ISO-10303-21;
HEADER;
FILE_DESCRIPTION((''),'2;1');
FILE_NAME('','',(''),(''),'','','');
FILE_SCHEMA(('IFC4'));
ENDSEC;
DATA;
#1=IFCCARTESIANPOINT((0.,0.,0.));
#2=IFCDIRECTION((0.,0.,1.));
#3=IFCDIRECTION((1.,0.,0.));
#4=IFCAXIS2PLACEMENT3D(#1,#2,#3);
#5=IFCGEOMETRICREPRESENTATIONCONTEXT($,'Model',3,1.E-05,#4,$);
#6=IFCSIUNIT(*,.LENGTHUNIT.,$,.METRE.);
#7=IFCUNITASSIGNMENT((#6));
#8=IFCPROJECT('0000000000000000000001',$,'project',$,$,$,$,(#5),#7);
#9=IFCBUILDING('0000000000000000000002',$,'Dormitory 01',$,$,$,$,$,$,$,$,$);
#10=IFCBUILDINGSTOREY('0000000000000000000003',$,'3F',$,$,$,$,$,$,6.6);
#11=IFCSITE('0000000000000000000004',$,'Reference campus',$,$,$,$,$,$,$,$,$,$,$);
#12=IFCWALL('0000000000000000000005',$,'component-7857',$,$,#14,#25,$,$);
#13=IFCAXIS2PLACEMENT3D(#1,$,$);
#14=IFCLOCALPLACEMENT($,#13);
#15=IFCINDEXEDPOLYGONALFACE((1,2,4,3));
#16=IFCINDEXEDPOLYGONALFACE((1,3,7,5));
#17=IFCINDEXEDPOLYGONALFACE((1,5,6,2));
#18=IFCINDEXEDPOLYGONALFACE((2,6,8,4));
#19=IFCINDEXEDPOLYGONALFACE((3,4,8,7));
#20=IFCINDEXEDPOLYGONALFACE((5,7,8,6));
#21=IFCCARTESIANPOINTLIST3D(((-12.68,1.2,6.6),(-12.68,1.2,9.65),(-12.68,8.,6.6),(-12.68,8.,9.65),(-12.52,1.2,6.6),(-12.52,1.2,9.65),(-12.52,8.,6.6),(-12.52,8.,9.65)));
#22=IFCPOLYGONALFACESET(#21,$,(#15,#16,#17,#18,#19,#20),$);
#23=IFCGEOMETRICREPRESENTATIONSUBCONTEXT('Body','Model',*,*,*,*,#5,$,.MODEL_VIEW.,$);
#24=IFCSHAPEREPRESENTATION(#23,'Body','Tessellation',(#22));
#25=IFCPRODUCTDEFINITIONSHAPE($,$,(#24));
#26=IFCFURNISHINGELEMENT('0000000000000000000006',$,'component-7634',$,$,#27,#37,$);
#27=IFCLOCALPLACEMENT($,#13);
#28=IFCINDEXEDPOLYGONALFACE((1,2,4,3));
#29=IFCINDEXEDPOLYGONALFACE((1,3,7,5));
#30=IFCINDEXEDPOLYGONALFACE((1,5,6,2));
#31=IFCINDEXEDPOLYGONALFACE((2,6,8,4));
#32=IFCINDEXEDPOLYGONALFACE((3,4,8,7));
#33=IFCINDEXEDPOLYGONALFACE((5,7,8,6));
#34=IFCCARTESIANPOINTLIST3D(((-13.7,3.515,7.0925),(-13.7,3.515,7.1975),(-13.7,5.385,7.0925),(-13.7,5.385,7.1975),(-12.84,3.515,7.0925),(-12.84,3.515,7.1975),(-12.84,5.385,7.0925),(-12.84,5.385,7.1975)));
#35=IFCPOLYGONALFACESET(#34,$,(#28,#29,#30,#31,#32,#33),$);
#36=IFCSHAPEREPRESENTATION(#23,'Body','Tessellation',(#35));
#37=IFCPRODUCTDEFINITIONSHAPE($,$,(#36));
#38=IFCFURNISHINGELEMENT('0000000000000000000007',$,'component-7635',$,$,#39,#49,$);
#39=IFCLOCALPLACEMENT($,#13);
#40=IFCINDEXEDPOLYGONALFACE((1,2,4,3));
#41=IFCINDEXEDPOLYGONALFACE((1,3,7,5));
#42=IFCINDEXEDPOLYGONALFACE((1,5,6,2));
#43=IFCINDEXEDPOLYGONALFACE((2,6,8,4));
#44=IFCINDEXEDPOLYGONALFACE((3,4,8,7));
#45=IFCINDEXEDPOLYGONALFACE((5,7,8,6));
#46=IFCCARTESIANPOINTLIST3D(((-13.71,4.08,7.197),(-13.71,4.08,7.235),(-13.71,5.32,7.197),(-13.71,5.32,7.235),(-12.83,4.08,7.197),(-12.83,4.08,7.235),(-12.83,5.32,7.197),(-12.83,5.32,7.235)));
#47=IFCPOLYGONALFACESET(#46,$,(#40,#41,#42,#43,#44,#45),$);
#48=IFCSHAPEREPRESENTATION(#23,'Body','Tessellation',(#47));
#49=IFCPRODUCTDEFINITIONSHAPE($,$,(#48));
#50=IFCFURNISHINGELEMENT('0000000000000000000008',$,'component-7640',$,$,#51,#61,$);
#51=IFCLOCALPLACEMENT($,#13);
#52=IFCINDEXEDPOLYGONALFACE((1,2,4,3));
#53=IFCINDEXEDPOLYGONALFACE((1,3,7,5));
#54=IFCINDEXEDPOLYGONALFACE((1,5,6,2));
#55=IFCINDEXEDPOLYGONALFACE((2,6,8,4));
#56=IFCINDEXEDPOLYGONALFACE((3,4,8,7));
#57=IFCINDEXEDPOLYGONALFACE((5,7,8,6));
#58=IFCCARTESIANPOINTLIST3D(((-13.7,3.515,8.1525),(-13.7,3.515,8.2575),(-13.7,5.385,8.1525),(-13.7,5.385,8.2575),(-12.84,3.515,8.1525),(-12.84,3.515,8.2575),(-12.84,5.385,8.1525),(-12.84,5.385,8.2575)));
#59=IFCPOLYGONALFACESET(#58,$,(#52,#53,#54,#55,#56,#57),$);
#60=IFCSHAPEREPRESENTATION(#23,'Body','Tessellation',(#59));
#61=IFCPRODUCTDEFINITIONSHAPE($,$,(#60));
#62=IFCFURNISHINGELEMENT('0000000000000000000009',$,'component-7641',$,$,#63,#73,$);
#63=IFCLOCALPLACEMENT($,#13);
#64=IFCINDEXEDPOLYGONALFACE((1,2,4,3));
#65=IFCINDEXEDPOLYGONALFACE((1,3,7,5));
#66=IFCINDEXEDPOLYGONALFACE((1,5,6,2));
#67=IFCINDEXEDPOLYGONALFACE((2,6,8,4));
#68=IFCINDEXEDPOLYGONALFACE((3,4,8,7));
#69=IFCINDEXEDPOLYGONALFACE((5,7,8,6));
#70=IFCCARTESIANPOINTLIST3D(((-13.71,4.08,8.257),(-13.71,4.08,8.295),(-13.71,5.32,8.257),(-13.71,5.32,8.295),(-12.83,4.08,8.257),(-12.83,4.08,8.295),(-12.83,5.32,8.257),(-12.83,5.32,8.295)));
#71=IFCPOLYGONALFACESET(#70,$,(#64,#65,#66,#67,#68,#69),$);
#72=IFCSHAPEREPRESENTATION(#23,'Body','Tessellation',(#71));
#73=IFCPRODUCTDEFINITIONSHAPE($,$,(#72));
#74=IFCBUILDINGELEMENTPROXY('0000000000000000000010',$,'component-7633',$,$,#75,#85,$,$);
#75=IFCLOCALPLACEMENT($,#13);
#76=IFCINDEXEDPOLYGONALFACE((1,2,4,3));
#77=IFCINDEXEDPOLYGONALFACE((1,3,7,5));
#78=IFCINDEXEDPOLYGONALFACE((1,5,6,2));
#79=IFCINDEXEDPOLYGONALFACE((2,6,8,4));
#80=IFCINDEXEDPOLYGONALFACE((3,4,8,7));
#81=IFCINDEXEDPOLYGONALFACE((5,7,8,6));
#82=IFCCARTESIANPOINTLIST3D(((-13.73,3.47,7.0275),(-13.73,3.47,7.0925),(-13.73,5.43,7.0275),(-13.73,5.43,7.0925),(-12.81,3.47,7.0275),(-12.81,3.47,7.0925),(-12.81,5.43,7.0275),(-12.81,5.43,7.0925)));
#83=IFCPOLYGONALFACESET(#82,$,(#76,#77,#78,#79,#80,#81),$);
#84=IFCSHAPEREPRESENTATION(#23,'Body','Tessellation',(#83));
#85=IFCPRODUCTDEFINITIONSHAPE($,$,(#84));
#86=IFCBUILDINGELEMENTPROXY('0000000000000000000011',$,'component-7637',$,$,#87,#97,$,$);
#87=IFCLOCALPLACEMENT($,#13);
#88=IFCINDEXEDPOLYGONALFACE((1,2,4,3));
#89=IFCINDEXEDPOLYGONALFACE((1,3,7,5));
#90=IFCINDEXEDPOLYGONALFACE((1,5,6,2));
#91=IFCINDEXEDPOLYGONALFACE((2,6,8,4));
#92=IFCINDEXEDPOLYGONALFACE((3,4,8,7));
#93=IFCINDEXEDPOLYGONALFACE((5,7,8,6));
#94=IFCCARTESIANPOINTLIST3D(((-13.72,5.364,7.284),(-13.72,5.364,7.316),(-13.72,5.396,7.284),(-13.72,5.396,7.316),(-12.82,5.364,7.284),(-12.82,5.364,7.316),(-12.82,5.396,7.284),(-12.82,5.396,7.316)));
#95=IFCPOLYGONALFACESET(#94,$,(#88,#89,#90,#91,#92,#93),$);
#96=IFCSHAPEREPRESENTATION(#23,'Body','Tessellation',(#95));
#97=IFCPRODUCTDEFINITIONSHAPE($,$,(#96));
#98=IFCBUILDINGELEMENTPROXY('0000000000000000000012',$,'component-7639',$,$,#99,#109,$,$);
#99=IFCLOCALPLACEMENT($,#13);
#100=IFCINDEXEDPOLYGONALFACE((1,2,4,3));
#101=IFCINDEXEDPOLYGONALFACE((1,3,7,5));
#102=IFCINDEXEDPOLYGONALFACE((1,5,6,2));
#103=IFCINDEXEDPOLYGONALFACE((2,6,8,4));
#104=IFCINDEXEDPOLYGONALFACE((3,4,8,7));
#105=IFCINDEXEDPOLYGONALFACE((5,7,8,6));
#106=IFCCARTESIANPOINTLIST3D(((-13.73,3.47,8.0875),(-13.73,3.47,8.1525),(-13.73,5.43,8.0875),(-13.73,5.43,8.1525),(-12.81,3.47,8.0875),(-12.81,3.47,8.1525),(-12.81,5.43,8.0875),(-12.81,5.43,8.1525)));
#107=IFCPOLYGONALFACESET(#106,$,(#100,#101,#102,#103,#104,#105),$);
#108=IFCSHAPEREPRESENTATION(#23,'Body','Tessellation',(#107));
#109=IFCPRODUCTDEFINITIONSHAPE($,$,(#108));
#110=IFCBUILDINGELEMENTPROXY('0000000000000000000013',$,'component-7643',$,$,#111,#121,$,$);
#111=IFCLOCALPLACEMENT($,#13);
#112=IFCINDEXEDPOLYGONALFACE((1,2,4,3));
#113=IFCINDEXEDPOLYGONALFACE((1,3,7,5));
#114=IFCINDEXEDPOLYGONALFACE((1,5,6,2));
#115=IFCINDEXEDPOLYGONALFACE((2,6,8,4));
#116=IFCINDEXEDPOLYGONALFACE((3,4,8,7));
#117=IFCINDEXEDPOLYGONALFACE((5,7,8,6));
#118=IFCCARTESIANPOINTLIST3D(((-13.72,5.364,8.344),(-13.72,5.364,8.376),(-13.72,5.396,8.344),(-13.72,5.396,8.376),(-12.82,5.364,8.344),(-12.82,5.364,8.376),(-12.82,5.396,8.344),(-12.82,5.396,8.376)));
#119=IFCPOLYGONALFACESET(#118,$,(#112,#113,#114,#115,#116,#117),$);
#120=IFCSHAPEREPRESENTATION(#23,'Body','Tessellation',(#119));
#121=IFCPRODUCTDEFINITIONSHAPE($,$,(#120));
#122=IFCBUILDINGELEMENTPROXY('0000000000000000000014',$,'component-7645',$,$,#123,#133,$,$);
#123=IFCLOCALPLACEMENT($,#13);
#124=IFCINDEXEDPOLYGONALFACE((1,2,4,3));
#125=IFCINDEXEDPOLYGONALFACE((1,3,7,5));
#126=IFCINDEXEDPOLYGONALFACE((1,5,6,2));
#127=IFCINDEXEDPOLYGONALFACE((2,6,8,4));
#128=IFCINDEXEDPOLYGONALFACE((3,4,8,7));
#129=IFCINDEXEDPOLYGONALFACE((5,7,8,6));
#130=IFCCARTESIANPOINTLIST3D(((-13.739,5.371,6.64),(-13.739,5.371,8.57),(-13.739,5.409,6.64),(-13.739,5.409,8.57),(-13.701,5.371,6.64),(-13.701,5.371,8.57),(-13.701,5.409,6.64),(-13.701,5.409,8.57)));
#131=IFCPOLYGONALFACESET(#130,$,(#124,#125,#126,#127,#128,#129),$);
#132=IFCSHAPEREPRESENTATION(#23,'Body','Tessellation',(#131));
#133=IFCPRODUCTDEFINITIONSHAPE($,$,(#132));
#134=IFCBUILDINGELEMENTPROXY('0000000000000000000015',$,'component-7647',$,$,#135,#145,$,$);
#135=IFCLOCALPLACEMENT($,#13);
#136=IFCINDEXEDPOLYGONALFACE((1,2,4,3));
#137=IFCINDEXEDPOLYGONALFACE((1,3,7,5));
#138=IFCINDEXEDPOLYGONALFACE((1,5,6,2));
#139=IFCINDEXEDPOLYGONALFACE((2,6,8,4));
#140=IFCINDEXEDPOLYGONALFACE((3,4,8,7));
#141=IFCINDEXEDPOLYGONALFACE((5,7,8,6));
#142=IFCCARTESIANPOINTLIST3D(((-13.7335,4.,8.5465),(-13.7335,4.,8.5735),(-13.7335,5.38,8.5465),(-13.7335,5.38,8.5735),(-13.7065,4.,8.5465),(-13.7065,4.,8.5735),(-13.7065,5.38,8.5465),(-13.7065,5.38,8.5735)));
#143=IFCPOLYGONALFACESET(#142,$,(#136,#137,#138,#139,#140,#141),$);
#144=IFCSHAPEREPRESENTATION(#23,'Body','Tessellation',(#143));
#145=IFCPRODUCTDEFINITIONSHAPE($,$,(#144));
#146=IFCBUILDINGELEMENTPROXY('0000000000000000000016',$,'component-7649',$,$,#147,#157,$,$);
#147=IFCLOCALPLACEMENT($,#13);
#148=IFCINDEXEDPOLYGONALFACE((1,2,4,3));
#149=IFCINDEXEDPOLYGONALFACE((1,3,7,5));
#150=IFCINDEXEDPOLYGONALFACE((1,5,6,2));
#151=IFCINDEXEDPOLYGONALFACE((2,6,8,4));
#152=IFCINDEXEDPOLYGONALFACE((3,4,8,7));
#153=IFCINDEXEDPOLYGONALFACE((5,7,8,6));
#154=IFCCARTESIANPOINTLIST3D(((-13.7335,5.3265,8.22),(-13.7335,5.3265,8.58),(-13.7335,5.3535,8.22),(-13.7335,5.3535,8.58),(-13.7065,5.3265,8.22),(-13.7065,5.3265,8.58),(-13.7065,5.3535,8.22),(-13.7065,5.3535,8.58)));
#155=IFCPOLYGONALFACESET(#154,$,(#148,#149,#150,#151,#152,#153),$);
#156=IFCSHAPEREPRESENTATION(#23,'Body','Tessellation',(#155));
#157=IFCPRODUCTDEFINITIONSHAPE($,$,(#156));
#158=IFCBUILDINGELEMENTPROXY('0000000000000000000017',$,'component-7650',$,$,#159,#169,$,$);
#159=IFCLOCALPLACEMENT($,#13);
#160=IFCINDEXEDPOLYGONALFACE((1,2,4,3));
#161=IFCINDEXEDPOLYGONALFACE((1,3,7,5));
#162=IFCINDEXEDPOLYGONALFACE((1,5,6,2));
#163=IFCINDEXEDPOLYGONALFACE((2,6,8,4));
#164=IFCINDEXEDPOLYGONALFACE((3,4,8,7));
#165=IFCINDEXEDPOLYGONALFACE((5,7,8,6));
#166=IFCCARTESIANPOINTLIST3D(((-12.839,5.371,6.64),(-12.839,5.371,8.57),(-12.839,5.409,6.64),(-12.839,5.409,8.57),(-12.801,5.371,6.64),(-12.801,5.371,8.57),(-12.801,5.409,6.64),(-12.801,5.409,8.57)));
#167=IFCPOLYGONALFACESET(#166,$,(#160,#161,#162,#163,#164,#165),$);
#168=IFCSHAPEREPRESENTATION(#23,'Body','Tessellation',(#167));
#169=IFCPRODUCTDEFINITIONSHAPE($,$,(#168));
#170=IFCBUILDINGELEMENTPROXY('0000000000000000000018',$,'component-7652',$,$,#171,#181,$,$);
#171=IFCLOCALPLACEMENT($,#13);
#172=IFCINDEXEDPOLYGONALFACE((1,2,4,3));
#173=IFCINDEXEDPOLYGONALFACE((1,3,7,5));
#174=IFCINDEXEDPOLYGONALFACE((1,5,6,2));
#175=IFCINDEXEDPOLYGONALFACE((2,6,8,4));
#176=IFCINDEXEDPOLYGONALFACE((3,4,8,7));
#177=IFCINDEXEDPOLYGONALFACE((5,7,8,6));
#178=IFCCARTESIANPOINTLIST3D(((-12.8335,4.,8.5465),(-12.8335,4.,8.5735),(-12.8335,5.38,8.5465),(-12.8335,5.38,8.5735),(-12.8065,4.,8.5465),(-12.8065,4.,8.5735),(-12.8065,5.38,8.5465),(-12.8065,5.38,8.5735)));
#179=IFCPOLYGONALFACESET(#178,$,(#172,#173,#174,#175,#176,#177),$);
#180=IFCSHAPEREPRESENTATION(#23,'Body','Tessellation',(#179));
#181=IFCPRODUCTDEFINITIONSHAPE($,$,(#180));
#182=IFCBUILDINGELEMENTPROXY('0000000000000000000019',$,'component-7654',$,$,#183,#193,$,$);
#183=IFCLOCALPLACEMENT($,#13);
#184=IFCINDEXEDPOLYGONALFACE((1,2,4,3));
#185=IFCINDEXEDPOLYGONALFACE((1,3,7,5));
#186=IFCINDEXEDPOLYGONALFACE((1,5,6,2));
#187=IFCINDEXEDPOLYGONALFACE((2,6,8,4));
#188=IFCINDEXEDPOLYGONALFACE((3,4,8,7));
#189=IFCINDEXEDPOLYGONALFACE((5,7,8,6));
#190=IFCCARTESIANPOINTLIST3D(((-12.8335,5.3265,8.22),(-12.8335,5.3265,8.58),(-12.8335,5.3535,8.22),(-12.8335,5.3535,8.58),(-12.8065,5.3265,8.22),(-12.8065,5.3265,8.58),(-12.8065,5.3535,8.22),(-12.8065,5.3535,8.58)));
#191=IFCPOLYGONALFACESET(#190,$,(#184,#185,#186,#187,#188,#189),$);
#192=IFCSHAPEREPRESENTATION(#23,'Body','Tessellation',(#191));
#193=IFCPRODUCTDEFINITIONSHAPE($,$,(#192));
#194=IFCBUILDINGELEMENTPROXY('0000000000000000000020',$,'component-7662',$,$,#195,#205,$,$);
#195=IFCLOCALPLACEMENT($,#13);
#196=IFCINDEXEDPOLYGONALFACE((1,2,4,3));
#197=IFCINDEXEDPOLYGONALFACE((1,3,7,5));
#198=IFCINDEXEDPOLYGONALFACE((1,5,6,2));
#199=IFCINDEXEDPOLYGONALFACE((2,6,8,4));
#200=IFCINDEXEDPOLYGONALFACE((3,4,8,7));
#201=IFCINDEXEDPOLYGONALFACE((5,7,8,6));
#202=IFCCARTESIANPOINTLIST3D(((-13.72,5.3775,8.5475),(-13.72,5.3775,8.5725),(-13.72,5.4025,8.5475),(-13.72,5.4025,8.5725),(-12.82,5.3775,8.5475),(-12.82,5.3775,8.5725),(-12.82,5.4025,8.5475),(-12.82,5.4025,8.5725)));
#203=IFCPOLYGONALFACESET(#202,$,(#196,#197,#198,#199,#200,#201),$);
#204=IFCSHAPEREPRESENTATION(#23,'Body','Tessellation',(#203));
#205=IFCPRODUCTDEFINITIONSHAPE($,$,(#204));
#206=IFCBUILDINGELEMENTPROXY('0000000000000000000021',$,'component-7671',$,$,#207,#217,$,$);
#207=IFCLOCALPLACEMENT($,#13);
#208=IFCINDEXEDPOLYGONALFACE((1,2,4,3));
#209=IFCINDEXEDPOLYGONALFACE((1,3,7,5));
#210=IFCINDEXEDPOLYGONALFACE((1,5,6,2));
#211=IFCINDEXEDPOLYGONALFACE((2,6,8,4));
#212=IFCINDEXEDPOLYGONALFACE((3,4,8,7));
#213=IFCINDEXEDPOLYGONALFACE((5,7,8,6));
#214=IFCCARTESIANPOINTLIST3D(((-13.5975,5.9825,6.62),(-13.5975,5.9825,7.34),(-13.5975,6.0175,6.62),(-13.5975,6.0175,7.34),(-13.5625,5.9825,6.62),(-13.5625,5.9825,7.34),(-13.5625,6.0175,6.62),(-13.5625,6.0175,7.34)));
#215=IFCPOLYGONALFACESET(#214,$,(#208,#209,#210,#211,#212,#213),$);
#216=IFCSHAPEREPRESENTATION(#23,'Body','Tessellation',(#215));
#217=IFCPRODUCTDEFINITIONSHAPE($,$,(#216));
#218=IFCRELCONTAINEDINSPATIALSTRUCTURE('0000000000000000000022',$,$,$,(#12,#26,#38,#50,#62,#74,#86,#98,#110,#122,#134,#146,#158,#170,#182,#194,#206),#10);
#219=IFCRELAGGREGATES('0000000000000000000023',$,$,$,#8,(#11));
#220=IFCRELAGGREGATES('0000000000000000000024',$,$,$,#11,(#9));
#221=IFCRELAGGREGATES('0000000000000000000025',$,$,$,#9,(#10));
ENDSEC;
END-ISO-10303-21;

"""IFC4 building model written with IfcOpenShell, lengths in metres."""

from ifc_helpers import new_model, si_unit, frame, origin, origin_with_axes, origin_2d, place, context, subcontext, project, spatial, rectangle, extrude, element, save


model = new_model("IFC4")

# Units and contexts
model_context = context("Model", 3, precision=1e-05, world=origin_with_axes())
body_context = subcontext(model_context, "Body", "Model", "MODEL_VIEW")
ifc_project = project(units=[si_unit("LENGTHUNIT", "METRE")], contexts=[model_context])

# Site, building, storey
site = spatial("IfcSite", under=ifc_project, Name="Reference campus")
building = spatial("IfcBuilding", under=site, Name="Dormitory 01")
storey = spatial("IfcBuildingStorey", under=building, Name="3F", Elevation=6.6)

# Wall
wall_placement = place(None, frame((-12.6, 4.6, 6.6), z_axis=(0.0, 0.0, 1.0), x_axis=(1.0, 0.0, 0.0)))
element("IfcWall", 1, at=wall_placement, inside=storey, Name="component-7857", context=body_context, shape_type="SweptSolid", body=[
    extrude(rectangle(XDim=0.16, YDim=6.8, at=origin_2d()), origin(), (0.0, 0.0, 1.0), 3.05),
])

# Furnishing elements
furnishing_1_placement = place(None, frame((-13.27, 4.45, 7.0925), z_axis=(0.0, 0.0, 1.0), x_axis=(1.0, 0.0, 0.0)))
element("IfcFurnishingElement", 2, at=furnishing_1_placement, inside=storey, Name="component-7634", context=body_context, shape_type="SweptSolid", body=[
    extrude(rectangle(XDim=0.86, YDim=1.87, at=origin_2d()), origin(), (0.0, 0.0, 1.0), 0.105),
])
furnishing_2_placement = place(None, frame((-13.27, 4.7, 7.197), z_axis=(0.0, 0.0, 1.0), x_axis=(1.0, 0.0, 0.0)))
element("IfcFurnishingElement", 3, at=furnishing_2_placement, inside=storey, Name="component-7635", context=body_context, shape_type="SweptSolid", body=[
    extrude(rectangle(XDim=0.88, YDim=1.24, at=origin_2d()), origin(), (0.0, 0.0, 1.0), 0.038),
])
furnishing_3_placement = place(None, frame((-13.27, 4.45, 8.1525), z_axis=(0.0, 0.0, 1.0), x_axis=(1.0, 0.0, 0.0)))
element("IfcFurnishingElement", 4, at=furnishing_3_placement, inside=storey, Name="component-7640", context=body_context, shape_type="SweptSolid", body=[
    extrude(rectangle(XDim=0.86, YDim=1.87, at=origin_2d()), origin(), (0.0, 0.0, 1.0), 0.105),
])
furnishing_4_placement = place(None, frame((-13.27, 4.7, 8.257), z_axis=(0.0, 0.0, 1.0), x_axis=(1.0, 0.0, 0.0)))
element("IfcFurnishingElement", 5, at=furnishing_4_placement, inside=storey, Name="component-7641", context=body_context, shape_type="SweptSolid", body=[
    extrude(rectangle(XDim=0.88, YDim=1.24, at=origin_2d()), origin(), (0.0, 0.0, 1.0), 0.038),
])

# Building element proxies
proxy_1_placement = place(None, frame((-13.27, 4.45, 7.0275), z_axis=(0.0, 0.0, 1.0), x_axis=(1.0, 0.0, 0.0)))
element("IfcBuildingElementProxy", 6, at=proxy_1_placement, inside=storey, Name="component-7633", context=body_context, shape_type="SweptSolid", body=[
    extrude(rectangle(XDim=0.92, YDim=1.96, at=origin_2d()), origin(), (0.0, 0.0, 1.0), 0.065),
])
proxy_2_placement = place(None, frame((-13.27, 5.38, 7.284), z_axis=(0.0, 0.0, 1.0), x_axis=(1.0, 0.0, 0.0)))
element("IfcBuildingElementProxy", 7, at=proxy_2_placement, inside=storey, Name="component-7637", context=body_context, shape_type="SweptSolid", body=[
    extrude(rectangle(XDim=0.9, YDim=0.032, at=origin_2d()), origin(), (0.0, 0.0, 1.0), 0.032),
])
proxy_3_placement = place(None, frame((-13.27, 4.45, 8.0875), z_axis=(0.0, 0.0, 1.0), x_axis=(1.0, 0.0, 0.0)))
element("IfcBuildingElementProxy", 8, at=proxy_3_placement, inside=storey, Name="component-7639", context=body_context, shape_type="SweptSolid", body=[
    extrude(rectangle(XDim=0.92, YDim=1.96, at=origin_2d()), origin(), (0.0, 0.0, 1.0), 0.065),
])
proxy_4_placement = place(None, frame((-13.27, 5.38, 8.344), z_axis=(0.0, 0.0, 1.0), x_axis=(1.0, 0.0, 0.0)))
element("IfcBuildingElementProxy", 9, at=proxy_4_placement, inside=storey, Name="component-7643", context=body_context, shape_type="SweptSolid", body=[
    extrude(rectangle(XDim=0.9, YDim=0.032, at=origin_2d()), origin(), (0.0, 0.0, 1.0), 0.032),
])
proxy_5_placement = place(None, frame((-13.72, 5.39, 6.64), z_axis=(0.0, 0.0, 1.0), x_axis=(1.0, 0.0, 0.0)))
element("IfcBuildingElementProxy", 10, at=proxy_5_placement, inside=storey, Name="component-7645", context=body_context, shape_type="SweptSolid", body=[
    extrude(rectangle(XDim=0.038, YDim=0.038, at=origin_2d()), origin(), (0.0, 0.0, 1.0), 1.93),
])
proxy_6_placement = place(None, frame((-13.72, 4.69, 8.5465), z_axis=(0.0, 0.0, 1.0), x_axis=(1.0, 0.0, 0.0)))
element("IfcBuildingElementProxy", 11, at=proxy_6_placement, inside=storey, Name="component-7647", context=body_context, shape_type="SweptSolid", body=[
    extrude(rectangle(XDim=0.027, YDim=1.38, at=origin_2d()), origin(), (0.0, 0.0, 1.0), 0.027),
])
proxy_7_placement = place(None, frame((-13.72, 5.34, 8.22), z_axis=(0.0, 0.0, 1.0), x_axis=(1.0, 0.0, 0.0)))
element("IfcBuildingElementProxy", 12, at=proxy_7_placement, inside=storey, Name="component-7649", context=body_context, shape_type="SweptSolid", body=[
    extrude(rectangle(XDim=0.027, YDim=0.027, at=origin_2d()), origin(), (0.0, 0.0, 1.0), 0.36),
])
proxy_8_placement = place(None, frame((-12.82, 5.39, 6.64), z_axis=(0.0, 0.0, 1.0), x_axis=(1.0, 0.0, 0.0)))
element("IfcBuildingElementProxy", 13, at=proxy_8_placement, inside=storey, Name="component-7650", context=body_context, shape_type="SweptSolid", body=[
    extrude(rectangle(XDim=0.038, YDim=0.038, at=origin_2d()), origin(), (0.0, 0.0, 1.0), 1.93),
])
proxy_9_placement = place(None, frame((-12.82, 4.69, 8.5465), z_axis=(0.0, 0.0, 1.0), x_axis=(1.0, 0.0, 0.0)))
element("IfcBuildingElementProxy", 14, at=proxy_9_placement, inside=storey, Name="component-7652", context=body_context, shape_type="SweptSolid", body=[
    extrude(rectangle(XDim=0.027, YDim=1.38, at=origin_2d()), origin(), (0.0, 0.0, 1.0), 0.027),
])
proxy_10_placement = place(None, frame((-12.82, 5.34, 8.22), z_axis=(0.0, 0.0, 1.0), x_axis=(1.0, 0.0, 0.0)))
element("IfcBuildingElementProxy", 15, at=proxy_10_placement, inside=storey, Name="component-7654", context=body_context, shape_type="SweptSolid", body=[
    extrude(rectangle(XDim=0.027, YDim=0.027, at=origin_2d()), origin(), (0.0, 0.0, 1.0), 0.36),
])
proxy_11_placement = place(None, frame((-13.27, 5.39, 8.5475), z_axis=(0.0, 0.0, 1.0), x_axis=(1.0, 0.0, 0.0)))
element("IfcBuildingElementProxy", 16, at=proxy_11_placement, inside=storey, Name="component-7662", context=body_context, shape_type="SweptSolid", body=[
    extrude(rectangle(XDim=0.9, YDim=0.025, at=origin_2d()), origin(), (0.0, 0.0, 1.0), 0.025),
])
for number, where, z_axis, x_axis, name in (
    (17, (-13.58, 6.0, 6.62), (0.0, 0.0, 1.0), (1.0, 0.0, 0.0), "component-7671"),
):
    element("IfcBuildingElementProxy", number, at=place(None, frame(where, z_axis=z_axis, x_axis=x_axis)), inside=storey, Name=name, context=body_context, shape_type="SweptSolid", body=[
        extrude(rectangle(XDim=0.035, YDim=0.035, at=origin_2d()), origin(), (0.0, 0.0, 1.0), 0.72),
    ])

save(model, "model.ifc")
